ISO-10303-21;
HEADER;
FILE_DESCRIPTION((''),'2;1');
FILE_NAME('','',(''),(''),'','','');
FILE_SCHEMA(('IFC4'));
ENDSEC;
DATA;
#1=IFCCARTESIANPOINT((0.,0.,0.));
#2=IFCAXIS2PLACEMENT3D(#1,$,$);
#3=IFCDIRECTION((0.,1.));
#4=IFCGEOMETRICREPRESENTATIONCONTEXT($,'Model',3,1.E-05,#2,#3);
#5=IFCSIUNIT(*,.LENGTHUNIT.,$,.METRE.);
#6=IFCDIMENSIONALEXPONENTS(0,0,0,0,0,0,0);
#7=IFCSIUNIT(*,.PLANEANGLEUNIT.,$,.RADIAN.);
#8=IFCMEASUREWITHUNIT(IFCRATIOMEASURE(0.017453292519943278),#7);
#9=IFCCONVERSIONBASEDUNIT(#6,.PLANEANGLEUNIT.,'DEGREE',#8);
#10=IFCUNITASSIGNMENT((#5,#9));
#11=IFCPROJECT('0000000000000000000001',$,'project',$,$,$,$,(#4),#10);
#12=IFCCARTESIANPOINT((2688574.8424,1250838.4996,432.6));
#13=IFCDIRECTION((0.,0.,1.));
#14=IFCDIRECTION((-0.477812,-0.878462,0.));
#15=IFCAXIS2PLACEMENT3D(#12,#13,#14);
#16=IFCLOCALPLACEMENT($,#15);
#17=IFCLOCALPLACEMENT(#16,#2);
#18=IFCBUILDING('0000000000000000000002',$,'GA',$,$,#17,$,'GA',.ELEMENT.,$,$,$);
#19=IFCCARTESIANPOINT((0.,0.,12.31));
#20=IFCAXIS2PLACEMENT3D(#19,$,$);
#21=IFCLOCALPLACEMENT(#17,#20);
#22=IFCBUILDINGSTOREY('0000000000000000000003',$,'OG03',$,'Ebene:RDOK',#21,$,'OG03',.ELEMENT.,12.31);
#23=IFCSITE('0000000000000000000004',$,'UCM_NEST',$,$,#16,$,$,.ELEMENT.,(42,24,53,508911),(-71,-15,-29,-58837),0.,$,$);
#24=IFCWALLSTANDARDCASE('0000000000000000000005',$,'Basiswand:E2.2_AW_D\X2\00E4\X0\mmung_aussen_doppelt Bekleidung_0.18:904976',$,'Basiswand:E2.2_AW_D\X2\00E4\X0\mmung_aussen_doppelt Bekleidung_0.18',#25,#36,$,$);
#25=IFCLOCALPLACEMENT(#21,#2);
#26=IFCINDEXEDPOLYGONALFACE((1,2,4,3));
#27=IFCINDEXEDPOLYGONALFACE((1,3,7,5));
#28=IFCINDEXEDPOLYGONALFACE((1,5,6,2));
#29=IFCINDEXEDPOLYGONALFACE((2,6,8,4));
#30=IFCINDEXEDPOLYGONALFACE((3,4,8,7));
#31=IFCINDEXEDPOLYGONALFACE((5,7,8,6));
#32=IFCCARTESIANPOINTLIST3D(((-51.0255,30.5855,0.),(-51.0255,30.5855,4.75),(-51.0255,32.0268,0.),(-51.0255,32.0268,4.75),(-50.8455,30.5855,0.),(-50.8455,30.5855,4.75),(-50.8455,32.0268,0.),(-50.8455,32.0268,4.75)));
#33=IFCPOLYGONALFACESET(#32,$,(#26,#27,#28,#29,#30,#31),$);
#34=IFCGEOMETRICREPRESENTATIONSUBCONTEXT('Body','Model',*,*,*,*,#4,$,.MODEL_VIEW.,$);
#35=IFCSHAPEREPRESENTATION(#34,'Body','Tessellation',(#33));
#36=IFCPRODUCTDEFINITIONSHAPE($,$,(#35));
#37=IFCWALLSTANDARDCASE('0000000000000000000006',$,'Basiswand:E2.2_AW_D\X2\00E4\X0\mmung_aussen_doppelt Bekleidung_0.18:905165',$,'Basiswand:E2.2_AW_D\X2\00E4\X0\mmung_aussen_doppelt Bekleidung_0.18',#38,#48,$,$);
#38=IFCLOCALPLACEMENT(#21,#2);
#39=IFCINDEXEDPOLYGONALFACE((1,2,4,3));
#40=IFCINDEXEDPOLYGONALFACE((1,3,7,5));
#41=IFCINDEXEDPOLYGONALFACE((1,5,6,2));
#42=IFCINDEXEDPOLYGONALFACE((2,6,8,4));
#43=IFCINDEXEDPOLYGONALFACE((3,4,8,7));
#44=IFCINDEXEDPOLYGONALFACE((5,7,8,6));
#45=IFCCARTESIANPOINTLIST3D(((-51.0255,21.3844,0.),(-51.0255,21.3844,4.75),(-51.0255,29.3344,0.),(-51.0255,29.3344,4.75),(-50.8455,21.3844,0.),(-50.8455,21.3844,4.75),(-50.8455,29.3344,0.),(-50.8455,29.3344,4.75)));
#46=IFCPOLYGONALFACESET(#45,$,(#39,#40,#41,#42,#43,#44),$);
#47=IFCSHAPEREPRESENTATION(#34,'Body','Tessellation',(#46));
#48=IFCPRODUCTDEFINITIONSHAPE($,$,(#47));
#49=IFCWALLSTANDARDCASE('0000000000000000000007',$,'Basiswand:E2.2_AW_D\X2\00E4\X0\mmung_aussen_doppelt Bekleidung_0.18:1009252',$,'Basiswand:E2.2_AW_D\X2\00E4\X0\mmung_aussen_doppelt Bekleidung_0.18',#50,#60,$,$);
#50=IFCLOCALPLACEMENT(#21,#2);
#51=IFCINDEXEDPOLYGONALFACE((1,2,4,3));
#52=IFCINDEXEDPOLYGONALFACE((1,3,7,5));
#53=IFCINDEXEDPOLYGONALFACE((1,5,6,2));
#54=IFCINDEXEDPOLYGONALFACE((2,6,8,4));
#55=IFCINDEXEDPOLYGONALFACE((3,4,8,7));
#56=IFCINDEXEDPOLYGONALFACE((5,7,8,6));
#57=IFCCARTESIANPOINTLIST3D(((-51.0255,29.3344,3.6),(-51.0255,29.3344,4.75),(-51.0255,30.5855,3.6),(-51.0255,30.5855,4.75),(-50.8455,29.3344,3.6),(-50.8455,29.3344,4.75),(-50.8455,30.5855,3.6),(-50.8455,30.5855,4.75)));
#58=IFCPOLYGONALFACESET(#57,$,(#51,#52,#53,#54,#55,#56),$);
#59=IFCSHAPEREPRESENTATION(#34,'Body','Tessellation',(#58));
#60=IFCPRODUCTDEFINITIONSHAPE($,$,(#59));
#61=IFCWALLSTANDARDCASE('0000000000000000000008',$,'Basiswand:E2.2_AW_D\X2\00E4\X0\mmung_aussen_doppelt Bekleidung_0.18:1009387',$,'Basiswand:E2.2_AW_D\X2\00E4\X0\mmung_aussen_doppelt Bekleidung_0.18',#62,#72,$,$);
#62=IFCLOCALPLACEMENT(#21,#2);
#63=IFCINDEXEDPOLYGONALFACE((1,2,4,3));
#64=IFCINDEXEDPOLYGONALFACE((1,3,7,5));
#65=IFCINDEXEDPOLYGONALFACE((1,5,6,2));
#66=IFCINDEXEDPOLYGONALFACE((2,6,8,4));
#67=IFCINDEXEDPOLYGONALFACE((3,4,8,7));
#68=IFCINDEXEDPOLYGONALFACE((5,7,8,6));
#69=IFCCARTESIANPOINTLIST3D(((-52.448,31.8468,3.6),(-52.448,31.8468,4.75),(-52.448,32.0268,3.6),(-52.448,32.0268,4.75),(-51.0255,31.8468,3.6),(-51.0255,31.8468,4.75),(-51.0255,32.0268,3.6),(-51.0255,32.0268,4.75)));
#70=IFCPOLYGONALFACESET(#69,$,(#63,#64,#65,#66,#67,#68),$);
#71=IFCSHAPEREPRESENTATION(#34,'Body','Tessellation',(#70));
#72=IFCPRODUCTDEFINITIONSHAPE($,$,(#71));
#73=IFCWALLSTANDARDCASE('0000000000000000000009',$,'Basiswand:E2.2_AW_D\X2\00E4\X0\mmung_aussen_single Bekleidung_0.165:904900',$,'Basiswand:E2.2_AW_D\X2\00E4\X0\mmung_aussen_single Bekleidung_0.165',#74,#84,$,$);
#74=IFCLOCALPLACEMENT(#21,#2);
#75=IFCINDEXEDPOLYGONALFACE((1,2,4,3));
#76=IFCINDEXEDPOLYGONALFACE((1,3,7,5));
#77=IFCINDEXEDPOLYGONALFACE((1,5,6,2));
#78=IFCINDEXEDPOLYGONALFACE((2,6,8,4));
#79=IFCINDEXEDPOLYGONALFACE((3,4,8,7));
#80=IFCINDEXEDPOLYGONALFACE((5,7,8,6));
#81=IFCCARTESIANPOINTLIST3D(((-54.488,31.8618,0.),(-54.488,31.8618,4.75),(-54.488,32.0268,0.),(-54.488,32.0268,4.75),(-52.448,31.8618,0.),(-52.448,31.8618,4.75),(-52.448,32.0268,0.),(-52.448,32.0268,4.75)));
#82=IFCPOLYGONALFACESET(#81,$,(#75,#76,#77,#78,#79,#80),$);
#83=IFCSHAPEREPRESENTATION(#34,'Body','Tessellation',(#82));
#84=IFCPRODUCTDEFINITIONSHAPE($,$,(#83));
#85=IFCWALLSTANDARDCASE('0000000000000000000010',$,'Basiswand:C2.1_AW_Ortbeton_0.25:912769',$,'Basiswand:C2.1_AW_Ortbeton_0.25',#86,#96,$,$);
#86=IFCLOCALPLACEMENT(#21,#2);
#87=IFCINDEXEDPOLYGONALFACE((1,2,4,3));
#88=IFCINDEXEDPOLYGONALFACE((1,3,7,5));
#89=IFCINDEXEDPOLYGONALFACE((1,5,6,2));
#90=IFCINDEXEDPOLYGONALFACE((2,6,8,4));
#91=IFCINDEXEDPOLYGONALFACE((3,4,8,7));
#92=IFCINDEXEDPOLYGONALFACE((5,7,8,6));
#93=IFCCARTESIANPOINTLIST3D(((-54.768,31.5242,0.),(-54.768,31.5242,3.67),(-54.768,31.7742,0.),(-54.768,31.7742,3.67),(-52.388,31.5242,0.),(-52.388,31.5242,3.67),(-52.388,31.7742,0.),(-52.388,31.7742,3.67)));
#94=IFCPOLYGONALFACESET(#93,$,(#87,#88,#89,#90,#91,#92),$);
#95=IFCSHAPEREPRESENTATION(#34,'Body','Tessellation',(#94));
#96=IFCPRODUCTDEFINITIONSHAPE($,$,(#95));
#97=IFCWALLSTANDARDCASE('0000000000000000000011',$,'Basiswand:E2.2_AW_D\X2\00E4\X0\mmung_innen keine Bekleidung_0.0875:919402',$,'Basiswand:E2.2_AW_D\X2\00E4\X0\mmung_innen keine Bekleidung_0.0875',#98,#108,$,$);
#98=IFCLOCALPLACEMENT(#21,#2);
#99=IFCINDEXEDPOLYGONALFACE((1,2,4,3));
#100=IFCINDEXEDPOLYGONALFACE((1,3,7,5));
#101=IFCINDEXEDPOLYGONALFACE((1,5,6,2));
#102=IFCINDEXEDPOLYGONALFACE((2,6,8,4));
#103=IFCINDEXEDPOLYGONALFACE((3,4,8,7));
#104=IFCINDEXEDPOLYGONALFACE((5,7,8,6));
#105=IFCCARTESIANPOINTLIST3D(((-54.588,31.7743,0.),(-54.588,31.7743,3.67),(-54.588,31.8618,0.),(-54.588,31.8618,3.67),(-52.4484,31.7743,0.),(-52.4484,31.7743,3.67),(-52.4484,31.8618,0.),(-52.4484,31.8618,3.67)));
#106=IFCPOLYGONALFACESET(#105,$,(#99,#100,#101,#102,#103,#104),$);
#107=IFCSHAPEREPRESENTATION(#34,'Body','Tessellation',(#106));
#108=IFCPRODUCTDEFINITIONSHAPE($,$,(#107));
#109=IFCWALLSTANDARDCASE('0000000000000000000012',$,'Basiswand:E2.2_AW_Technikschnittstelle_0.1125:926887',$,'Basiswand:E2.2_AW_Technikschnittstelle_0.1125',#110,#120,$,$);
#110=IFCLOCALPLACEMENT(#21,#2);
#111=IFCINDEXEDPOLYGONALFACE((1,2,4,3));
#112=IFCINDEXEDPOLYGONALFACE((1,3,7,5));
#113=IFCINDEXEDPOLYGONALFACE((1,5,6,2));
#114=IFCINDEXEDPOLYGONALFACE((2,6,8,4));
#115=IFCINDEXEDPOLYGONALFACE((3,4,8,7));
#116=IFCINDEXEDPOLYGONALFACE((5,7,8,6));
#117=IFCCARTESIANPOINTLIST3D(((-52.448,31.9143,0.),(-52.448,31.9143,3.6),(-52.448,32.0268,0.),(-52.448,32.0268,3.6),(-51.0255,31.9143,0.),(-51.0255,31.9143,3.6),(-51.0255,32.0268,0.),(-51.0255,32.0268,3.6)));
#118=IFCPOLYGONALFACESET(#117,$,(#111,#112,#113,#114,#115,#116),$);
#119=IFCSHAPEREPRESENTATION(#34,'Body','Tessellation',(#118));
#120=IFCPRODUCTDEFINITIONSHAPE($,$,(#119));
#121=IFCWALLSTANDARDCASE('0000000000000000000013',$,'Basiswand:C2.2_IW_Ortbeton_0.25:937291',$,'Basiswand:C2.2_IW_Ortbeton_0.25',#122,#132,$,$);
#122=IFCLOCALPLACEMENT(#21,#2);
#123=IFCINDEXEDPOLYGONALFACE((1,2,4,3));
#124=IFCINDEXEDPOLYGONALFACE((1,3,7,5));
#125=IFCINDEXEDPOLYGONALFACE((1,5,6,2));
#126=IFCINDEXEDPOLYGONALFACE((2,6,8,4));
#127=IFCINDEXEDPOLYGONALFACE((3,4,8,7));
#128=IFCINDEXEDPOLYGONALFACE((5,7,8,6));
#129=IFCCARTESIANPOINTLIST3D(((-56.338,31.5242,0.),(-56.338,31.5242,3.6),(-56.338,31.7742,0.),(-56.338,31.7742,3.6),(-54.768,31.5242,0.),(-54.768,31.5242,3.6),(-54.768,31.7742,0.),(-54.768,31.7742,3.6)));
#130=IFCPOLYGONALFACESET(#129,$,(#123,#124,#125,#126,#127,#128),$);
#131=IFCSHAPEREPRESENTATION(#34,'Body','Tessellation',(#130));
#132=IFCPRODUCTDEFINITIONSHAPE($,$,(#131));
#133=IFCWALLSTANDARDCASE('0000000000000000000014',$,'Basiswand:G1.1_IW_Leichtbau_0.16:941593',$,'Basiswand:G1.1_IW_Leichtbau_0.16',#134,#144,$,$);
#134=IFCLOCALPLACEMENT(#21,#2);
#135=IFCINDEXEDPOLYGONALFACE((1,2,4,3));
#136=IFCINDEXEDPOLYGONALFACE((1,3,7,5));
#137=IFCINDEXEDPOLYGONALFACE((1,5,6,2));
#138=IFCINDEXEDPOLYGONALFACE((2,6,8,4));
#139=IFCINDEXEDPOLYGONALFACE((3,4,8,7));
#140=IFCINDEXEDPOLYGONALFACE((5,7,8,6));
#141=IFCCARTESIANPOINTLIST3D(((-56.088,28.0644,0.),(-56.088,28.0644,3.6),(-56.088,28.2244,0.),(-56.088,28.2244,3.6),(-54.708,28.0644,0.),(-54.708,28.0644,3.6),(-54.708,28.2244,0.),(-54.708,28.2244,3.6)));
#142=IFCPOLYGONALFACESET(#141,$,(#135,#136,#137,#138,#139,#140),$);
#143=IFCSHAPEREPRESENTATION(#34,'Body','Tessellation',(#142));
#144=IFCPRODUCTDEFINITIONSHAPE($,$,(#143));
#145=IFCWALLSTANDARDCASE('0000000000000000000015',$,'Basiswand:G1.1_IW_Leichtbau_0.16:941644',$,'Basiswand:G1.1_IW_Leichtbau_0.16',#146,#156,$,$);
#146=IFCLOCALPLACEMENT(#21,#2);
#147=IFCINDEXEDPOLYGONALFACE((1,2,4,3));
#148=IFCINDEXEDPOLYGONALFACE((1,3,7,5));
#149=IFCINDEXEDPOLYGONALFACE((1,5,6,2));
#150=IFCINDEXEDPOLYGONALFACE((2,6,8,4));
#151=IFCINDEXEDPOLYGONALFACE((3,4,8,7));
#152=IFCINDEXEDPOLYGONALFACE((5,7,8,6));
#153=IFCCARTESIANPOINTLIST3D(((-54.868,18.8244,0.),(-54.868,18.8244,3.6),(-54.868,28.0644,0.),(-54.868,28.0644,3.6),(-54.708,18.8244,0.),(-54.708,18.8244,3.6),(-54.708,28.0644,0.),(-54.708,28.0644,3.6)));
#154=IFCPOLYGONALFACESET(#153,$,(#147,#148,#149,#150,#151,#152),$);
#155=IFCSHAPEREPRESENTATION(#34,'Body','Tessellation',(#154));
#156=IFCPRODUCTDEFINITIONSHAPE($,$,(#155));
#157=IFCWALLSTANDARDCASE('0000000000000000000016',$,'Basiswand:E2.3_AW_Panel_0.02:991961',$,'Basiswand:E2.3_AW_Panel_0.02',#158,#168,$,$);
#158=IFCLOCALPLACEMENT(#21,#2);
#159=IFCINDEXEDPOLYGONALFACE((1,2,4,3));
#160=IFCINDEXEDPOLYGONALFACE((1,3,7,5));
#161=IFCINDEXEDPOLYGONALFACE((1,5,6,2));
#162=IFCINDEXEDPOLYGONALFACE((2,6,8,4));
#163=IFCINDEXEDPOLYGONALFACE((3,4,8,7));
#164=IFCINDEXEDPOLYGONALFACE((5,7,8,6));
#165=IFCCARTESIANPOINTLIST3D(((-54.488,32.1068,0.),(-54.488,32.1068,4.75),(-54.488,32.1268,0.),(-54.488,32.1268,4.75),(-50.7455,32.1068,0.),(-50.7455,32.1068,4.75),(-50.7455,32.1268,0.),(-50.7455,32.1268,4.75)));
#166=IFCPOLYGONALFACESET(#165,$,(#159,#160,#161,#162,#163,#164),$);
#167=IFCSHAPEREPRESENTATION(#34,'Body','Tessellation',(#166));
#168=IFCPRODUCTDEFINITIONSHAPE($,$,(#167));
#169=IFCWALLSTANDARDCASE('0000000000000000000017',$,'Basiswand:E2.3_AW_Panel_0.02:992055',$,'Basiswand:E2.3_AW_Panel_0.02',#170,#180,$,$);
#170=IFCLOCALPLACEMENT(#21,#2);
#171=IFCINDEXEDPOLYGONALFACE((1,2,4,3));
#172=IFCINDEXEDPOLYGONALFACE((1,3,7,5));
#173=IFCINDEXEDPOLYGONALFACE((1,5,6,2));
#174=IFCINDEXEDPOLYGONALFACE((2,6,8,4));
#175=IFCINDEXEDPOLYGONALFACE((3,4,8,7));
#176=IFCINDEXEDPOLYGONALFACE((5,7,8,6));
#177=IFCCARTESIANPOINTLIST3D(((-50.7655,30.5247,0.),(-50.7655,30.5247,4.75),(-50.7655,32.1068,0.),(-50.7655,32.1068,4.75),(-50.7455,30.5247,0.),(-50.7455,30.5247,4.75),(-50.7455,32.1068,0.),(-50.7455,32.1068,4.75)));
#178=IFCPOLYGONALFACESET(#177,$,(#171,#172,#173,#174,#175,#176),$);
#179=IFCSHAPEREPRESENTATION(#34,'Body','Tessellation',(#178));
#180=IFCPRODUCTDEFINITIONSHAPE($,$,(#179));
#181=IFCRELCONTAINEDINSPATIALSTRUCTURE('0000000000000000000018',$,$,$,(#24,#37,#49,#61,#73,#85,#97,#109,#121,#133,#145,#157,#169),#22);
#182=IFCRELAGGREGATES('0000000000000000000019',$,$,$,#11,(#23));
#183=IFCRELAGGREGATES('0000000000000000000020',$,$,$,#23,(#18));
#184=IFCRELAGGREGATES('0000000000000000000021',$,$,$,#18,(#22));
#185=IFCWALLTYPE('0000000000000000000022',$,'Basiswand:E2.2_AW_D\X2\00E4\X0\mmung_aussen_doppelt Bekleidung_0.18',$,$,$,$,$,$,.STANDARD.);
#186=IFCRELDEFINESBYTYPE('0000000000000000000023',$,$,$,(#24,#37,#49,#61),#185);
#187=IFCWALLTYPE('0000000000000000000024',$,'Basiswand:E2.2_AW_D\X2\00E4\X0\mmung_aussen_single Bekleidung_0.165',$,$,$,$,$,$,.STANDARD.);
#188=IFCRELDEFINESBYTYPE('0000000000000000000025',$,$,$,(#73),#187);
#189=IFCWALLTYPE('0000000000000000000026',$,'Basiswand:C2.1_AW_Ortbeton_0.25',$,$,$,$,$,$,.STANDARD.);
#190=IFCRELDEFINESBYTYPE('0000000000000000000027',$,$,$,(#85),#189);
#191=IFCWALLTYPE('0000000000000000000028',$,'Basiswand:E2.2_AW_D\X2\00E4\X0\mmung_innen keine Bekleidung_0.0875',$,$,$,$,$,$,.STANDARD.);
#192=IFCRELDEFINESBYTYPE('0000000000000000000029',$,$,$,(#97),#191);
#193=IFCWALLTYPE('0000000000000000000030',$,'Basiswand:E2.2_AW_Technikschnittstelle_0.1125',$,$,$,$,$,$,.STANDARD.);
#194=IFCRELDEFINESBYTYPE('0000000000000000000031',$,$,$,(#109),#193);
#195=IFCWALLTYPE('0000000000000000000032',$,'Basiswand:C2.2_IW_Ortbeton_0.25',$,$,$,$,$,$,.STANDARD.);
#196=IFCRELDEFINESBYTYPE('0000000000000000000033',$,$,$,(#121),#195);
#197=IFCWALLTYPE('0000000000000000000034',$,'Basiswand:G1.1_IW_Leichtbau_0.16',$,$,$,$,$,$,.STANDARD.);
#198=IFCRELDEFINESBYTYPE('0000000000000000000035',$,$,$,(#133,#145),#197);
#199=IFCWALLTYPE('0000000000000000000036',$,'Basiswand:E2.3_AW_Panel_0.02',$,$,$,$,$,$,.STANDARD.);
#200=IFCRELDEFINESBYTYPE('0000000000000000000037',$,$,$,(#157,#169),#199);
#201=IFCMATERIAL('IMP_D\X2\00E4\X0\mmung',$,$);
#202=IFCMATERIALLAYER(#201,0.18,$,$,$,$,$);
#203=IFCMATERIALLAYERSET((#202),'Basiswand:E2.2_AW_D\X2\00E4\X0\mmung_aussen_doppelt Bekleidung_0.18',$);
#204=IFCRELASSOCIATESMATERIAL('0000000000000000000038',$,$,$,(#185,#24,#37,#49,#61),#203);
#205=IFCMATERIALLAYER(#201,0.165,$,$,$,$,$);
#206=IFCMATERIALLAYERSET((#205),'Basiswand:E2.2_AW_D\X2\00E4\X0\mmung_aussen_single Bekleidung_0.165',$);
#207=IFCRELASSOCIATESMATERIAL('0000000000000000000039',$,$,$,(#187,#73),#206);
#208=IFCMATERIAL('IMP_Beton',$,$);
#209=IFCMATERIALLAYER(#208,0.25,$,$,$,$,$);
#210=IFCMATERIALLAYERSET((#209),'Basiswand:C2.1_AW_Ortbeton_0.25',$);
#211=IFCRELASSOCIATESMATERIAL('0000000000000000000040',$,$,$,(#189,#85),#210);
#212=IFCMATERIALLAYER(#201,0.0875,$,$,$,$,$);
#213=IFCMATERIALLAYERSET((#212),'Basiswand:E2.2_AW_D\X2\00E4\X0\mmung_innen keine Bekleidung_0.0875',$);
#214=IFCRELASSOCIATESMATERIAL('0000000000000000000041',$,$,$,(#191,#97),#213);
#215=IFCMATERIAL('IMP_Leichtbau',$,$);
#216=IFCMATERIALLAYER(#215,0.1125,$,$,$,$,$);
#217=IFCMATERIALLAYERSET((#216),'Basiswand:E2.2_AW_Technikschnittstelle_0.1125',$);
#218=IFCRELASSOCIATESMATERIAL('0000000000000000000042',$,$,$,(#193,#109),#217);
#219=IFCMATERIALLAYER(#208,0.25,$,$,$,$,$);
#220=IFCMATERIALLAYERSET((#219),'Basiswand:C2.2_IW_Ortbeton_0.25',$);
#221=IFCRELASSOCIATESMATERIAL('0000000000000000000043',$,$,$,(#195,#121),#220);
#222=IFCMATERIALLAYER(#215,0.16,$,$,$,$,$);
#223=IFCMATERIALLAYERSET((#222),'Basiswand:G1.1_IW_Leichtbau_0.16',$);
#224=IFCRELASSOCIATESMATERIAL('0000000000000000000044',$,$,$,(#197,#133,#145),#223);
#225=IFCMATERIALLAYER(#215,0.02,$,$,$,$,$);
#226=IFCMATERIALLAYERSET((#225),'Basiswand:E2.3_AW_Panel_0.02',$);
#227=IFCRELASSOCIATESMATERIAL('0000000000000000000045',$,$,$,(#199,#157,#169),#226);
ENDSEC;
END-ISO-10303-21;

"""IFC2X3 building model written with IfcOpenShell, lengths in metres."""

from ifc_helpers import new_model, entity, si_unit, converted_unit, direction, frame, frame_2d, origin, place, context, subcontext, project, spatial, rectangle, extrude, material, layer, layer_set, layer_usage, type_object, element, save


model = new_model("IFC2X3")

# Units and contexts
model_context = context("Model", 3, precision=1e-05, world=origin(), true_north=direction((0.0, 1.0)))
body_context = subcontext(model_context, "Body", "Model", "MODEL_VIEW")
ifc_project = project(units=[si_unit("LENGTHUNIT", "METRE"), converted_unit("PLANEANGLEUNIT", "DEGREE", entity("IfcRatioMeasure", 0.017453292519943278), si_unit("PLANEANGLEUNIT", "RADIAN"), dimensions=[0, 0, 0, 0, 0, 0, 0])], contexts=[model_context])

# Site, building, storey
site_placement = place(None, frame((2688574.8424, 1250838.4996, 432.6), z_axis=(0.0, 0.0, 1.0), x_axis=(-0.477812, -0.878462, 0.0)))
site = spatial("IfcSite", under=ifc_project, at=site_placement, Name="UCM_NEST", CompositionType="ELEMENT", RefLatitude=(42, 24, 53, 508911), RefLongitude=(-71, -15, -29, -58837), RefElevation=0.0)
building_placement = place(site_placement, origin())
building = spatial("IfcBuilding", under=site, at=building_placement, Name="GA", LongName="GA", CompositionType="ELEMENT")
storey_placement = place(building_placement, frame((0.0, 0.0, 12.31)))
storey = spatial("IfcBuildingStorey", under=building, at=storey_placement, Name="OG03", ObjectType="Ebene:RDOK", LongName="OG03", CompositionType="ELEMENT", Elevation=12.31)

# Walls
ifc_material_1 = material(Name="IMP_Dämmung")
ifc_layer_1 = layer(ifc_material_1, 0.18)
ifc_layer_set_1 = layer_set([ifc_layer_1], Name="Basiswand:E2.2_AW_Dämmung_aussen_doppelt Bekleidung_0.18")
ifc_layer_usage_1 = layer_usage(ifc_layer_set_1, "AXIS2", "NEGATIVE", 0.09)
wall_type_1 = type_object("IfcWallType", Name="Basiswand:E2.2_AW_Dämmung_aussen_doppelt Bekleidung_0.18", PredefinedType="STANDARD", material=ifc_layer_set_1)
wall_1_placement = place(storey_placement, frame((-50.9355, 32.0268, 0.0), z_axis=(0.0, 0.0, 1.0), x_axis=(0.0, -1.0, 0.0)))
element("IfcWallStandardCase", 1, at=wall_1_placement, inside=storey, type_object=wall_type_1, material=ifc_layer_usage_1, Name="Basiswand:E2.2_AW_Dämmung_aussen_doppelt Bekleidung_0.18:904976", ObjectType="Basiswand:E2.2_AW_Dämmung_aussen_doppelt Bekleidung_0.18", context=body_context, shape_type="SweptSolid", body=[
    extrude(rectangle(XDim=1.4412, YDim=0.18, at=frame_2d((0.7206, 0.0), x_axis=(-1.0, 0.0))), origin(), (0.0, 0.0, 1.0), 4.75),
])
wall_2_placement = place(storey_placement, frame((-50.9355, 29.3344, 0.0), z_axis=(0.0, 0.0, 1.0), x_axis=(0.0, -1.0, 0.0)))
element("IfcWallStandardCase", 2, at=wall_2_placement, inside=storey, type_object=wall_type_1, material=ifc_layer_usage_1, Name="Basiswand:E2.2_AW_Dämmung_aussen_doppelt Bekleidung_0.18:905165", ObjectType="Basiswand:E2.2_AW_Dämmung_aussen_doppelt Bekleidung_0.18", context=body_context, shape_type="SweptSolid", body=[
    extrude(rectangle(XDim=7.95, YDim=0.18, at=frame_2d((3.975, 0.0), x_axis=(-1.0, 0.0))), origin(), (0.0, 0.0, 1.0), 4.75),
])
wall_3_placement = place(storey_placement, frame((-50.9355, 29.3344, 3.6), z_axis=(0.0, 0.0, 1.0), x_axis=(0.0, 1.0, 0.0)))
element("IfcWallStandardCase", 3, at=wall_3_placement, inside=storey, type_object=wall_type_1, material=ifc_layer_usage_1, Name="Basiswand:E2.2_AW_Dämmung_aussen_doppelt Bekleidung_0.18:1009252", ObjectType="Basiswand:E2.2_AW_Dämmung_aussen_doppelt Bekleidung_0.18", context=body_context, shape_type="SweptSolid", body=[
    extrude(rectangle(XDim=1.2511, YDim=0.18, at=frame_2d((0.6256, 0.0), x_axis=(-1.0, 0.0))), origin(), (0.0, 0.0, 1.0), 1.15),
])
wall_4_placement = place(storey_placement, frame((-51.0255, 31.9368, 3.6), z_axis=(0.0, 0.0, 1.0), x_axis=(-1.0, 0.0, 0.0)))
element("IfcWallStandardCase", 4, at=wall_4_placement, inside=storey, type_object=wall_type_1, material=ifc_layer_usage_1, Name="Basiswand:E2.2_AW_Dämmung_aussen_doppelt Bekleidung_0.18:1009387", ObjectType="Basiswand:E2.2_AW_Dämmung_aussen_doppelt Bekleidung_0.18", context=body_context, shape_type="SweptSolid", body=[
    extrude(rectangle(XDim=1.4225, YDim=0.18, at=frame_2d((0.7112, 0.0), x_axis=(-1.0, 0.0))), origin(), (0.0, 0.0, 1.0), 1.15),
])
ifc_layer_2 = layer(ifc_material_1, 0.165)
ifc_layer_set_2 = layer_set([ifc_layer_2], Name="Basiswand:E2.2_AW_Dämmung_aussen_single Bekleidung_0.165")
ifc_layer_usage_2 = layer_usage(ifc_layer_set_2, "AXIS2", "NEGATIVE", 0.0825)
wall_type_2 = type_object("IfcWallType", Name="Basiswand:E2.2_AW_Dämmung_aussen_single Bekleidung_0.165", PredefinedType="STANDARD", material=ifc_layer_set_2)
wall_5_placement = place(storey_placement, frame((-54.488, 31.9443, 0.0)))
element("IfcWallStandardCase", 5, at=wall_5_placement, inside=storey, type_object=wall_type_2, material=ifc_layer_usage_2, Name="Basiswand:E2.2_AW_Dämmung_aussen_single Bekleidung_0.165:904900", ObjectType="Basiswand:E2.2_AW_Dämmung_aussen_single Bekleidung_0.165", context=body_context, shape_type="SweptSolid", body=[
    extrude(rectangle(XDim=2.04, YDim=0.165, at=frame_2d((1.02, 0.0), x_axis=(-1.0, 0.0))), origin(), (0.0, 0.0, 1.0), 4.75),
])
ifc_material_2 = material(Name="IMP_Beton")
ifc_layer_3 = layer(ifc_material_2, 0.25)
ifc_layer_set_3 = layer_set([ifc_layer_3], Name="Basiswand:C2.1_AW_Ortbeton_0.25")
ifc_layer_usage_3 = layer_usage(ifc_layer_set_3, "AXIS2", "NEGATIVE", 0.125)
wall_type_3 = type_object("IfcWallType", Name="Basiswand:C2.1_AW_Ortbeton_0.25", PredefinedType="STANDARD", material=ifc_layer_set_3)
wall_6_placement = place(storey_placement, frame((-54.768, 31.6492, 0.0)))
element("IfcWallStandardCase", 6, at=wall_6_placement, inside=storey, type_object=wall_type_3, material=ifc_layer_usage_3, Name="Basiswand:C2.1_AW_Ortbeton_0.25:912769", ObjectType="Basiswand:C2.1_AW_Ortbeton_0.25", context=body_context, shape_type="SweptSolid", body=[
    extrude(rectangle(XDim=2.38, YDim=0.25, at=frame_2d((1.19, 0.0), x_axis=(-1.0, 0.0))), origin(), (0.0, 0.0, 1.0), 3.67),
])

# Walls
ifc_layer_4 = layer(ifc_material_1, 0.0875)
ifc_layer_set_4 = layer_set([ifc_layer_4], Name="Basiswand:E2.2_AW_Dämmung_innen keine Bekleidung_0.0875")
ifc_layer_usage_4 = layer_usage(ifc_layer_set_4, "AXIS2", "NEGATIVE", 0.0437)
wall_type_4 = type_object("IfcWallType", Name="Basiswand:E2.2_AW_Dämmung_innen keine Bekleidung_0.0875", PredefinedType="STANDARD", material=ifc_layer_set_4)
wall_7_placement = place(storey_placement, frame((-54.588, 31.818, 0.0)))
element("IfcWallStandardCase", 7, at=wall_7_placement, inside=storey, type_object=wall_type_4, material=ifc_layer_usage_4, Name="Basiswand:E2.2_AW_Dämmung_innen keine Bekleidung_0.0875:919402", ObjectType="Basiswand:E2.2_AW_Dämmung_innen keine Bekleidung_0.0875", context=body_context, shape_type="SweptSolid", body=[
    extrude(rectangle(XDim=2.1396, YDim=0.0875, at=frame_2d((1.0698, 0.0), x_axis=(-1.0, 0.0))), origin(), (0.0, 0.0, 1.0), 3.67),
])
ifc_material_3 = material(Name="IMP_Leichtbau")
ifc_layer_5 = layer(ifc_material_3, 0.1125)
ifc_layer_set_5 = layer_set([ifc_layer_5], Name="Basiswand:E2.2_AW_Technikschnittstelle_0.1125")
ifc_layer_usage_5 = layer_usage(ifc_layer_set_5, "AXIS2", "NEGATIVE", 0.0562)
wall_type_5 = type_object("IfcWallType", Name="Basiswand:E2.2_AW_Technikschnittstelle_0.1125", PredefinedType="STANDARD", material=ifc_layer_set_5)
wall_8_placement = place(storey_placement, frame((-52.448, 31.9705, 0.0)))
element("IfcWallStandardCase", 8, at=wall_8_placement, inside=storey, type_object=wall_type_5, material=ifc_layer_usage_5, Name="Basiswand:E2.2_AW_Technikschnittstelle_0.1125:926887", ObjectType="Basiswand:E2.2_AW_Technikschnittstelle_0.1125", context=body_context, shape_type="SweptSolid", body=[
    extrude(rectangle(XDim=1.4225, YDim=0.1125, at=frame_2d((0.7112, 0.0), x_axis=(-1.0, 0.0))), origin(), (0.0, 0.0, 1.0), 3.6),
])
ifc_layer_6 = layer(ifc_material_2, 0.25)
ifc_layer_set_6 = layer_set([ifc_layer_6], Name="Basiswand:C2.2_IW_Ortbeton_0.25")
ifc_layer_usage_6 = layer_usage(ifc_layer_set_6, "AXIS2", "NEGATIVE", 0.125)
wall_type_6 = type_object("IfcWallType", Name="Basiswand:C2.2_IW_Ortbeton_0.25", PredefinedType="STANDARD", material=ifc_layer_set_6)
wall_9_placement = place(storey_placement, frame((-54.768, 31.6492, 0.0), z_axis=(0.0, 0.0, 1.0), x_axis=(-1.0, 0.0, 0.0)))
element("IfcWallStandardCase", 9, at=wall_9_placement, inside=storey, type_object=wall_type_6, material=ifc_layer_usage_6, Name="Basiswand:C2.2_IW_Ortbeton_0.25:937291", ObjectType="Basiswand:C2.2_IW_Ortbeton_0.25", context=body_context, shape_type="SweptSolid", body=[
    extrude(rectangle(XDim=1.57, YDim=0.25, at=frame_2d((0.785, 0.0), x_axis=(-1.0, 0.0))), origin(), (0.0, 0.0, 1.0), 3.6),
])
ifc_layer_7 = layer(ifc_material_3, 0.16)
ifc_layer_set_7 = layer_set([ifc_layer_7], Name="Basiswand:G1.1_IW_Leichtbau_0.16")
ifc_layer_usage_7 = layer_usage(ifc_layer_set_7, "AXIS2", "NEGATIVE", 0.08)
wall_type_7 = type_object("IfcWallType", Name="Basiswand:G1.1_IW_Leichtbau_0.16", PredefinedType="STANDARD", material=ifc_layer_set_7)
wall_10_placement = place(storey_placement, frame((-56.088, 28.1444, 0.0)))
element("IfcWallStandardCase", 10, at=wall_10_placement, inside=storey, type_object=wall_type_7, material=ifc_layer_usage_7, Name="Basiswand:G1.1_IW_Leichtbau_0.16:941593", ObjectType="Basiswand:G1.1_IW_Leichtbau_0.16", context=body_context, shape_type="SweptSolid", body=[
    extrude(rectangle(XDim=1.38, YDim=0.16, at=frame_2d((0.69, 0.0), x_axis=(-1.0, 0.0))), origin(), (0.0, 0.0, 1.0), 3.6),
])
wall_11_placement = place(storey_placement, frame((-54.788, 28.0644, 0.0), z_axis=(0.0, 0.0, 1.0), x_axis=(0.0, -1.0, 0.0)))
element("IfcWallStandardCase", 11, at=wall_11_placement, inside=storey, type_object=wall_type_7, material=ifc_layer_usage_7, Name="Basiswand:G1.1_IW_Leichtbau_0.16:941644", ObjectType="Basiswand:G1.1_IW_Leichtbau_0.16", context=body_context, shape_type="SweptSolid", body=[
    extrude(rectangle(XDim=9.24, YDim=0.16, at=frame_2d((4.62, 0.0), x_axis=(-1.0, 0.0))), origin(), (0.0, 0.0, 1.0), 3.6),
])
ifc_layer_8 = layer(ifc_material_3, 0.02)
ifc_layer_set_8 = layer_set([ifc_layer_8], Name="Basiswand:E2.3_AW_Panel_0.02")
ifc_layer_usage_8 = layer_usage(ifc_layer_set_8, "AXIS2", "NEGATIVE", 0.01)
wall_type_8 = type_object("IfcWallType", Name="Basiswand:E2.3_AW_Panel_0.02", PredefinedType="STANDARD", material=ifc_layer_set_8)
wall_12_placement = place(storey_placement, frame((-54.488, 32.1168, 0.0)))
element("IfcWallStandardCase", 12, at=wall_12_placement, inside=storey, type_object=wall_type_8, material=ifc_layer_usage_8, Name="Basiswand:E2.3_AW_Panel_0.02:991961", ObjectType="Basiswand:E2.3_AW_Panel_0.02", context=body_context, shape_type="SweptSolid", body=[
    extrude(rectangle(XDim=3.7425, YDim=0.02, at=frame_2d((1.8712, 0.0), x_axis=(-1.0, 0.0))), origin(), (0.0, 0.0, 1.0), 4.75),
])
wall_13_placement = place(storey_placement, frame((-50.7555, 32.1068, 0.0), z_axis=(0.0, 0.0, 1.0), x_axis=(0.0, -1.0, 0.0)))
element("IfcWallStandardCase", 13, at=wall_13_placement, inside=storey, type_object=wall_type_8, material=ifc_layer_usage_8, Name="Basiswand:E2.3_AW_Panel_0.02:992055", ObjectType="Basiswand:E2.3_AW_Panel_0.02", context=body_context, shape_type="SweptSolid", body=[
    extrude(rectangle(XDim=1.5821, YDim=0.02, at=frame_2d((0.791, 0.0), x_axis=(-1.0, 0.0))), origin(), (0.0, 0.0, 1.0), 4.75),
])

save(model, "model.ifc")
